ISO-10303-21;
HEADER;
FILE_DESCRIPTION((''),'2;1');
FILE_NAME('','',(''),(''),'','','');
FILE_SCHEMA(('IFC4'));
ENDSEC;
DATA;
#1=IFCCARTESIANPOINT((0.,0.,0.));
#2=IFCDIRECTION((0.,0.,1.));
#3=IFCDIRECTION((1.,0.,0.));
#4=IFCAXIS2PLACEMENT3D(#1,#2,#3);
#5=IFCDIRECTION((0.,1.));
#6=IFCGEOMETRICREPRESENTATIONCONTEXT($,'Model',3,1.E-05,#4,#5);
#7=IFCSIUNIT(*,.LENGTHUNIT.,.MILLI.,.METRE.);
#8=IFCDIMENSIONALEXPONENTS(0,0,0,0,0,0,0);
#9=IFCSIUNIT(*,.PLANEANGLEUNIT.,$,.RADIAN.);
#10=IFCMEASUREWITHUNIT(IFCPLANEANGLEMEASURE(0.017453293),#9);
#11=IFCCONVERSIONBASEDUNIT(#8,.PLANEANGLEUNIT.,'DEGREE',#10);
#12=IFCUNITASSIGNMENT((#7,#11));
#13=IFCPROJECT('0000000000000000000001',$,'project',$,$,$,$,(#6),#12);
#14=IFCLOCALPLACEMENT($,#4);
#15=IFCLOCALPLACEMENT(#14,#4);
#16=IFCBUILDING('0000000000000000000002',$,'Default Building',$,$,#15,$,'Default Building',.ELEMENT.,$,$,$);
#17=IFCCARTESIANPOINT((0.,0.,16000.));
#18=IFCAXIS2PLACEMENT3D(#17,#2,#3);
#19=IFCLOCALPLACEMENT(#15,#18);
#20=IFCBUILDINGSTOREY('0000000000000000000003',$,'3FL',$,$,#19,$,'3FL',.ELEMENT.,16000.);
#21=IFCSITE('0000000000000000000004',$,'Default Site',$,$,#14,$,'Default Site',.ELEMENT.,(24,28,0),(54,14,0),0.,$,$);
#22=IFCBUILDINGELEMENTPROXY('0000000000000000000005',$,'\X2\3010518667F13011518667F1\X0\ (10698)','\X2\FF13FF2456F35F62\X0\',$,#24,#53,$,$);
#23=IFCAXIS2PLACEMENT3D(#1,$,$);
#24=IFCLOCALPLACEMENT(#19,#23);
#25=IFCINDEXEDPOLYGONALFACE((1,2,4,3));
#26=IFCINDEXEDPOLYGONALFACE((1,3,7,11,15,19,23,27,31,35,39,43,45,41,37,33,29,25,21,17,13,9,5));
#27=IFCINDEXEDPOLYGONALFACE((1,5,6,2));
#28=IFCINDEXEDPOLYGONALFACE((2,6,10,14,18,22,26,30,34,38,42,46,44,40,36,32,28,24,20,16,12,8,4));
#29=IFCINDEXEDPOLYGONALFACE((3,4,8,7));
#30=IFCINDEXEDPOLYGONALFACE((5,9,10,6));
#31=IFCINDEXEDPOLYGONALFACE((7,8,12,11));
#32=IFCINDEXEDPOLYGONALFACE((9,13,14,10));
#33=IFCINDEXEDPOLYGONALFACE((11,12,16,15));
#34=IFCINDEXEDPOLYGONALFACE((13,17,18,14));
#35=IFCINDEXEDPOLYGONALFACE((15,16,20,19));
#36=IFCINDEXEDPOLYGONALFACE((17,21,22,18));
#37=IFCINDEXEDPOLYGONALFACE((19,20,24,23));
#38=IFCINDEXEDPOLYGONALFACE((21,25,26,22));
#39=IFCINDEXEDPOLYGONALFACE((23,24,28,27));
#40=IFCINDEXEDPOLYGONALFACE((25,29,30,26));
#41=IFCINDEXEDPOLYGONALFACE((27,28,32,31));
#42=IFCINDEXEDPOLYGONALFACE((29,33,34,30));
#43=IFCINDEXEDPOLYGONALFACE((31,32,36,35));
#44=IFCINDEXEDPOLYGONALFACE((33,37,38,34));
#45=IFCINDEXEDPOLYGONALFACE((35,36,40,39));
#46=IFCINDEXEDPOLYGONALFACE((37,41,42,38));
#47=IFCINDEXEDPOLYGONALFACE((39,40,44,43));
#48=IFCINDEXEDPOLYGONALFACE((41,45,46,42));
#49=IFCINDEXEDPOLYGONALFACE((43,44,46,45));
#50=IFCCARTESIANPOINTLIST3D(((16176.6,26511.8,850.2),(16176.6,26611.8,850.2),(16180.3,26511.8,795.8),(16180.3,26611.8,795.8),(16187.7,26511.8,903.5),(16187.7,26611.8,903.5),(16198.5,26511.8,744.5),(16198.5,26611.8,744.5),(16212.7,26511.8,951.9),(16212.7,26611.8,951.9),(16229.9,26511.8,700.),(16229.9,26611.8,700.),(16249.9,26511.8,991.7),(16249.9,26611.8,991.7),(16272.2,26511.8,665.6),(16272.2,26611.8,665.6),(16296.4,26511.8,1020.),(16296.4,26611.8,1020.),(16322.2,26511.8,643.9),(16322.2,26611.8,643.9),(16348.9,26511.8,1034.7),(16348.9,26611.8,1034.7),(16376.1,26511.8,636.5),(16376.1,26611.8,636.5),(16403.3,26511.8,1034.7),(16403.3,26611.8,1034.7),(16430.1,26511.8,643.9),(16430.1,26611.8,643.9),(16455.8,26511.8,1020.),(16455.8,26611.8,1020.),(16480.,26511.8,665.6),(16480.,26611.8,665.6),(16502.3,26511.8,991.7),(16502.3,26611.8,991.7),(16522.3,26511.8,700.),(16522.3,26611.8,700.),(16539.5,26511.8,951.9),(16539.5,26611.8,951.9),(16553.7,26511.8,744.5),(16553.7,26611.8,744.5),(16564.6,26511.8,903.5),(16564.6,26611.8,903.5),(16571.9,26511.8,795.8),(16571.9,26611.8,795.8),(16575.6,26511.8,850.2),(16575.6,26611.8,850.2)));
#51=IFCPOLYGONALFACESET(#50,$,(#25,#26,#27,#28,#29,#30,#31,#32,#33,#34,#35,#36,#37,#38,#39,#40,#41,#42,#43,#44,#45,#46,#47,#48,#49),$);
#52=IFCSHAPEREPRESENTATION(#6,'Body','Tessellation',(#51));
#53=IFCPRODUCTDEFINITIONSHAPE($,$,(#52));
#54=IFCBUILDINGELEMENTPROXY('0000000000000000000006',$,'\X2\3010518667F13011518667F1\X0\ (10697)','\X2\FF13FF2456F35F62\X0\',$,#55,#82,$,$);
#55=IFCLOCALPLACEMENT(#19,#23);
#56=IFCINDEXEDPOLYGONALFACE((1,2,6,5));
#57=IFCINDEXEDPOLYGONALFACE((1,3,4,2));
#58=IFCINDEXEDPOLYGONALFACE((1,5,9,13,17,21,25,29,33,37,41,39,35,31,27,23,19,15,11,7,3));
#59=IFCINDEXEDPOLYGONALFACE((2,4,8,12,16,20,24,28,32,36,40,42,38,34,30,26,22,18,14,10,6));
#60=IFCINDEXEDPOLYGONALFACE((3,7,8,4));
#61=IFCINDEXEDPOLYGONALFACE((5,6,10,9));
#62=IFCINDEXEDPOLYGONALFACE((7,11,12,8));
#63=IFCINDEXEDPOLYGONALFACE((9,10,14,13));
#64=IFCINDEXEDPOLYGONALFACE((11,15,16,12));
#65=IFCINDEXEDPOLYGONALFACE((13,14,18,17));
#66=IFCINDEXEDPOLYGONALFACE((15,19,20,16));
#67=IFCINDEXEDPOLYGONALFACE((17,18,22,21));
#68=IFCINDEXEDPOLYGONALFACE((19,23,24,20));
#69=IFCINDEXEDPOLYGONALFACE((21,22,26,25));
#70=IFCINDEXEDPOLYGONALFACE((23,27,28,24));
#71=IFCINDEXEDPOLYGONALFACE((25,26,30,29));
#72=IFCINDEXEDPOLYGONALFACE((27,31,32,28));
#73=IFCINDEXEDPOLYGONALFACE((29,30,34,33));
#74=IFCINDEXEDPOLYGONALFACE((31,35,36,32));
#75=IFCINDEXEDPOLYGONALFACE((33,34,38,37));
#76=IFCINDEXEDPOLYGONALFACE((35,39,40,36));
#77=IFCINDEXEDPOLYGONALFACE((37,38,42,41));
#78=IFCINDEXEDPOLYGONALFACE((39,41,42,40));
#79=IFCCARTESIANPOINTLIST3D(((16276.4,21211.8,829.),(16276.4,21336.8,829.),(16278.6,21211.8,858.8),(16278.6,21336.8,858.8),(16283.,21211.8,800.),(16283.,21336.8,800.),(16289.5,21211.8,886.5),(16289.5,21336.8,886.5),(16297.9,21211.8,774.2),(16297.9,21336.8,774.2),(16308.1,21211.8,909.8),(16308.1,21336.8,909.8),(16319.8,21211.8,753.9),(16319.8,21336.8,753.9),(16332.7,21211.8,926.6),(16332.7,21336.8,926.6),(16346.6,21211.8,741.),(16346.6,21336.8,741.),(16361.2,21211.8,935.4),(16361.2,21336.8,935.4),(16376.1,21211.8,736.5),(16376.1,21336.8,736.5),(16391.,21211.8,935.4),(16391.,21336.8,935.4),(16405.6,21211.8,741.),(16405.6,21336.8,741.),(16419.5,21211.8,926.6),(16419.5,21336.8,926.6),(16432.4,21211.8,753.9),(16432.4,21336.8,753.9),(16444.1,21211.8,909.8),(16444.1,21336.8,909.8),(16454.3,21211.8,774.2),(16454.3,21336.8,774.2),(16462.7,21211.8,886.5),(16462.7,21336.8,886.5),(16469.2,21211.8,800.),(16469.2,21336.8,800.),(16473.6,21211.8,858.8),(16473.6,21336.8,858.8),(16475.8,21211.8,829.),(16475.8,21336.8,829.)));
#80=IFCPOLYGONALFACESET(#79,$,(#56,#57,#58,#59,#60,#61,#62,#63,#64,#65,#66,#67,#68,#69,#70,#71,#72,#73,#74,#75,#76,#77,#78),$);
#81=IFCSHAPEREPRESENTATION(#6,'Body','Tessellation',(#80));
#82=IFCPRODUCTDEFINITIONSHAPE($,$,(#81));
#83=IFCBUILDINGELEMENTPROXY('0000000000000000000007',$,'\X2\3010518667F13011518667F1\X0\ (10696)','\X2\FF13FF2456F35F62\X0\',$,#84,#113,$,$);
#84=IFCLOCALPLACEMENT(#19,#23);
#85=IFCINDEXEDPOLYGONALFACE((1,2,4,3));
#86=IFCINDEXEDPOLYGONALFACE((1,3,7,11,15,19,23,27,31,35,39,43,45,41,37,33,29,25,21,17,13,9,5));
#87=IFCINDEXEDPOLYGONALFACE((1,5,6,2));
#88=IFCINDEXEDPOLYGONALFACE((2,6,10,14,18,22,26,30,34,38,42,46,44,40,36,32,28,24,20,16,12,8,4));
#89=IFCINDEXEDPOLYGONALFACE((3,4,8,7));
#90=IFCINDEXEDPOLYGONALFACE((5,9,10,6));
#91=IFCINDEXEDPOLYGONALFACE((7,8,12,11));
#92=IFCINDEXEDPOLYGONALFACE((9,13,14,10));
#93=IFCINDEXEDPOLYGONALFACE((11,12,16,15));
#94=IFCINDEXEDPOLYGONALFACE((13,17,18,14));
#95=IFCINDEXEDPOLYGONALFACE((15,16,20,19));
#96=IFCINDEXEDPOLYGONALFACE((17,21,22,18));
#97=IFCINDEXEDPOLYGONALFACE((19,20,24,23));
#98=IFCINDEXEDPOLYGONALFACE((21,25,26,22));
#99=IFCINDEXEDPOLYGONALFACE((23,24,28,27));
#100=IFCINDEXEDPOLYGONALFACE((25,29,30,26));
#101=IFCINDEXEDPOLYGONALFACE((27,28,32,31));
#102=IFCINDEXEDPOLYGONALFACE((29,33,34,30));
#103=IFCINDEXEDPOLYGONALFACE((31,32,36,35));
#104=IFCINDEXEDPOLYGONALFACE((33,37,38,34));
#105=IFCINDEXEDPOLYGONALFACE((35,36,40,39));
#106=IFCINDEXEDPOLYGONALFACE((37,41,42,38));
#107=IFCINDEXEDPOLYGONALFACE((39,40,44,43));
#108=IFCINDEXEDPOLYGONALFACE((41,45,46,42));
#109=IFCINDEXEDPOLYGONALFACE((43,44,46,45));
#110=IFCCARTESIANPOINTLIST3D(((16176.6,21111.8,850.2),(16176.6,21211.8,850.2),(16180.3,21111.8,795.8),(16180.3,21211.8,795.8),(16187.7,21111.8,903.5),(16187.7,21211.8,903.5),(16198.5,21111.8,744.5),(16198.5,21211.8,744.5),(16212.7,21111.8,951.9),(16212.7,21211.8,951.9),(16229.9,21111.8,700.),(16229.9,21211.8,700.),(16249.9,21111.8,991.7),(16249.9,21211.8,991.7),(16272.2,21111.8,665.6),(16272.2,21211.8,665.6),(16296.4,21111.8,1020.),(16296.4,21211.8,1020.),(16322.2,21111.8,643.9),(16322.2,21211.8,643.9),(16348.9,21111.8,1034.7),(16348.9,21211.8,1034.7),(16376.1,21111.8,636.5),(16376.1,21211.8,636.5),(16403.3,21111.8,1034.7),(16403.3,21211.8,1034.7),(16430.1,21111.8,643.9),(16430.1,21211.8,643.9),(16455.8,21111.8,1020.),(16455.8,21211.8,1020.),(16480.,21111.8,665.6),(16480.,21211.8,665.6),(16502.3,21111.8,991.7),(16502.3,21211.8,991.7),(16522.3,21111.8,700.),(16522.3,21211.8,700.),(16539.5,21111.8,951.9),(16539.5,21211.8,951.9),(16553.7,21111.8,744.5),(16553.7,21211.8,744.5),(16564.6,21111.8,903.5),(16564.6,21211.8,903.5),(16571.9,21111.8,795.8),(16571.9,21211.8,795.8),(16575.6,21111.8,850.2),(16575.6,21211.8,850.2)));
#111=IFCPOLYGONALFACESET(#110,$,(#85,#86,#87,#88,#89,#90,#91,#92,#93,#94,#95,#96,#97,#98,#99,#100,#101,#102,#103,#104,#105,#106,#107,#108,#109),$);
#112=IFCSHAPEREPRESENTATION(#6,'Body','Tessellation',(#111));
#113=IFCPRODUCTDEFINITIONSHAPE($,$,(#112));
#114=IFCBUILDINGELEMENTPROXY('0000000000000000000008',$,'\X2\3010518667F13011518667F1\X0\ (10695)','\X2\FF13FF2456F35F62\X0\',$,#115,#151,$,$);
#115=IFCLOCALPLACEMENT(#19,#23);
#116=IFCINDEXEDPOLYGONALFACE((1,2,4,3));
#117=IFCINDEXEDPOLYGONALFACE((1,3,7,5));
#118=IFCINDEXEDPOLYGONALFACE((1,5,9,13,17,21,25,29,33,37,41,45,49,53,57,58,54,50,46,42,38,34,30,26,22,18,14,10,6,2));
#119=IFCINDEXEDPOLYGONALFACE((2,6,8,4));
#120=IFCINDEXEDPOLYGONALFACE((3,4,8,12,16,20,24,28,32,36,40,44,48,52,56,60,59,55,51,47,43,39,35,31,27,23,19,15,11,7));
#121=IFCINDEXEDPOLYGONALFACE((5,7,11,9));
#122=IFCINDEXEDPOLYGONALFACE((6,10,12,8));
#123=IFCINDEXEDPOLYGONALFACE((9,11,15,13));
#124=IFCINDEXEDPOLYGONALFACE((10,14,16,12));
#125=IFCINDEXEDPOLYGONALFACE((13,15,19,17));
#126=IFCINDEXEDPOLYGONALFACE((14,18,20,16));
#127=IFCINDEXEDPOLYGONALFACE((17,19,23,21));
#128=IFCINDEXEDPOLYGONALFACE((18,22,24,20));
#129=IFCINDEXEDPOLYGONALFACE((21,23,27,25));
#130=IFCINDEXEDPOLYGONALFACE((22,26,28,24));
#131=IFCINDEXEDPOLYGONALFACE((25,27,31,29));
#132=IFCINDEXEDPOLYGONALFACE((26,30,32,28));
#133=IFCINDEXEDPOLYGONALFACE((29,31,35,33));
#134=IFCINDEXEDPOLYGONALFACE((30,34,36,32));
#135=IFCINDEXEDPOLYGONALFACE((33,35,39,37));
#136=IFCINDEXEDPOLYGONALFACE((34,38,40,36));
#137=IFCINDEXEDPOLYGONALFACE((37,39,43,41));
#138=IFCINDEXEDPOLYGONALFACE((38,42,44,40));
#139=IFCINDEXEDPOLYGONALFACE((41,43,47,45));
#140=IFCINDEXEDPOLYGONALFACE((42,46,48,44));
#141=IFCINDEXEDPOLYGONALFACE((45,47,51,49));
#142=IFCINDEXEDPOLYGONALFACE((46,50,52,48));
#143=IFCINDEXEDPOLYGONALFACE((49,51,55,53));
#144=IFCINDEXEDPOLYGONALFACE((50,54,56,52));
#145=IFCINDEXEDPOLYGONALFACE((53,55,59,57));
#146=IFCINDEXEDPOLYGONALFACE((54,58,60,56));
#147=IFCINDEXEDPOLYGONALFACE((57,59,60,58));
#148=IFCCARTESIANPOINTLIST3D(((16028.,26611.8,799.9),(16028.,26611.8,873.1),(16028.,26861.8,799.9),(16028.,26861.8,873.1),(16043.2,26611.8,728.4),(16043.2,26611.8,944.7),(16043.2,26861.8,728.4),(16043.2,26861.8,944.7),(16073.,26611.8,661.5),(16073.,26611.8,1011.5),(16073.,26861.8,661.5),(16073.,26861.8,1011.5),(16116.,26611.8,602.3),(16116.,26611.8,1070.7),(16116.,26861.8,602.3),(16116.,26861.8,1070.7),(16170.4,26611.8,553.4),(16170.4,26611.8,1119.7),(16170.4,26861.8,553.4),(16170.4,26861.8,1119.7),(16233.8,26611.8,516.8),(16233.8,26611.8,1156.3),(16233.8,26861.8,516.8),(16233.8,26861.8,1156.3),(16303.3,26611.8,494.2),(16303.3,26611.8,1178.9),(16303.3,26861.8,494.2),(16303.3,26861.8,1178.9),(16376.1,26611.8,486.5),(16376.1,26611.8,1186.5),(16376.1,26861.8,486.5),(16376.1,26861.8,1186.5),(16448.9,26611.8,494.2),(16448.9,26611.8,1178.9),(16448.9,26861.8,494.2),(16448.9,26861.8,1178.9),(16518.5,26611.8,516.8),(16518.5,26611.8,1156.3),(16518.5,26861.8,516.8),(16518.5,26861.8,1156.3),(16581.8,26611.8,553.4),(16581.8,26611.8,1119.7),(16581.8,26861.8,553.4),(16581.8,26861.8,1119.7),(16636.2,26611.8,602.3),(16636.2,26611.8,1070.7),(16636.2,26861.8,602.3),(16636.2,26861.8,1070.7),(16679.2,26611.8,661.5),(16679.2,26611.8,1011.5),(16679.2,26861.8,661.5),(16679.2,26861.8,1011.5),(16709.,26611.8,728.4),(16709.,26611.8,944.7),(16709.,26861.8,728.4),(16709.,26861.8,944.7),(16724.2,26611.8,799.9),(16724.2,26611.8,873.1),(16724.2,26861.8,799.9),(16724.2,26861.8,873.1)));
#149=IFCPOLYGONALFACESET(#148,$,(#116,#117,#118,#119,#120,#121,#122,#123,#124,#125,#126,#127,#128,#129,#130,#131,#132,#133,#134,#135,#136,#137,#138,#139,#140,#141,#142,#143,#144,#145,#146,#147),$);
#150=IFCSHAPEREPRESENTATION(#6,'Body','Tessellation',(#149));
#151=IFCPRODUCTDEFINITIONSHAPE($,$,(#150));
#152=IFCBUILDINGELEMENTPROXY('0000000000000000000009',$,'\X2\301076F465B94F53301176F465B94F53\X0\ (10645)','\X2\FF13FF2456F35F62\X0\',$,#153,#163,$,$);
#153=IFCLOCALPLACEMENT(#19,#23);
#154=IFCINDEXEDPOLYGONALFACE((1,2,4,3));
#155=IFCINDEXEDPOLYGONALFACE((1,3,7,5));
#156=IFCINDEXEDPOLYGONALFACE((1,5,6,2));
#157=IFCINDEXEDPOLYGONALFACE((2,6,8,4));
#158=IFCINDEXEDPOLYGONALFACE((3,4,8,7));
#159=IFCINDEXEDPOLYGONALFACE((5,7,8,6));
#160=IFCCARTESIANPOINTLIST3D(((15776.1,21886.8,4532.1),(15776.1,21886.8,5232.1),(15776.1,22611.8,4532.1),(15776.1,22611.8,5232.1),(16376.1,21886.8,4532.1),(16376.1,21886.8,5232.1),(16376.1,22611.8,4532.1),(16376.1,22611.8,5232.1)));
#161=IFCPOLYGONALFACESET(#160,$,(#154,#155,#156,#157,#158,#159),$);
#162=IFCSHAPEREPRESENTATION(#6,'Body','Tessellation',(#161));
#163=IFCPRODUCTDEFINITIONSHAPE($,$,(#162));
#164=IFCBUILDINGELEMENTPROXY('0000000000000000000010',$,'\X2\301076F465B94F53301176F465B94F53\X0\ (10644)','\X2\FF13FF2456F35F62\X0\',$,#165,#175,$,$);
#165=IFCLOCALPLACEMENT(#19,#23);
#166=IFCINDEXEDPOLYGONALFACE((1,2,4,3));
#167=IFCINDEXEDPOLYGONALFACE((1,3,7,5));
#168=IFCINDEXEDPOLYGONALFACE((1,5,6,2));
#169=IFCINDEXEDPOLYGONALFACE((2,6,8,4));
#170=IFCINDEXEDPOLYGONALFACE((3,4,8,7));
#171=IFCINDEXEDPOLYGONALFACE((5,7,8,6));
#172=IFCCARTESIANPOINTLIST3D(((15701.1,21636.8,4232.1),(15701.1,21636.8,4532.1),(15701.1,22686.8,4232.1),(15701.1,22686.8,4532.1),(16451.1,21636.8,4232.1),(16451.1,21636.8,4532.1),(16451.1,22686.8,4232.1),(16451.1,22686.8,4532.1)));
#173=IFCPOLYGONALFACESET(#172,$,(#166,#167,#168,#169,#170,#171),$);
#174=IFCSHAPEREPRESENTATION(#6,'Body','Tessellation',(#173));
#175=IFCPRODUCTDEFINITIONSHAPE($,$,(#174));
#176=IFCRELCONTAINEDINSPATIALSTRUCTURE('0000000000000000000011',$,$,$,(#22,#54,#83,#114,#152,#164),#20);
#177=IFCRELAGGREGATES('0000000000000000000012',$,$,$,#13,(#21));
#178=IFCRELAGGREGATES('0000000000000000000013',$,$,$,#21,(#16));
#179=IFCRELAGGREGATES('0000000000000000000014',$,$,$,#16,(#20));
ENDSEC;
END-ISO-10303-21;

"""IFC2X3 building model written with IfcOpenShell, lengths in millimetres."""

from ifc_helpers import new_model, entity, si_unit, converted_unit, direction, frame, origin_with_axes, origin_2d_with_axis, place, context, project, spatial, rectangle, circle, extrude, source, transform, mapped, element, save


model = new_model("IFC2X3")

# Units and contexts
model_context = context("Model", 3, precision=1e-05, world=origin_with_axes(), true_north=direction((0.0, 1.0)))
ifc_project = project(units=[si_unit("LENGTHUNIT", "METRE", prefix="MILLI"), converted_unit("PLANEANGLEUNIT", "DEGREE", entity("IfcPlaneAngleMeasure", 0.017453293), si_unit("PLANEANGLEUNIT", "RADIAN"), dimensions=[0, 0, 0, 0, 0, 0, 0])], contexts=[model_context])

# Site, building, storey
site_placement = place(None, origin_with_axes())
site = spatial("IfcSite", under=ifc_project, at=site_placement, Name="Default Site", LongName="Default Site", CompositionType="ELEMENT", RefLatitude=(24, 28, 0), RefLongitude=(54, 14, 0), RefElevation=0.0)
building_placement = place(site_placement, origin_with_axes())
building = spatial("IfcBuilding", under=site, at=building_placement, Name="Default Building", LongName="Default Building", CompositionType="ELEMENT")
storey_placement = place(building_placement, frame((0.0, 0.0, 16000.0), z_axis=(0.0, 0.0, 1.0), x_axis=(1.0, 0.0, 0.0)))
storey = spatial("IfcBuildingStorey", under=building, at=storey_placement, Name="3FL", LongName="3FL", CompositionType="ELEMENT", Elevation=16000.0)

# Building element proxies
shared_shape_1 = source(origin_with_axes(), model_context, "Body", "SweptSolid", [
    extrude(circle(Radius=200.0, at=origin_2d_with_axis()), frame((0.0, 0.0, 0.0), z_axis=(0.0, 0.0, 1.0), x_axis=(1.0, 0.0, 0.0)), (0.0, 0.0, 1.0), 100.0),
])
proxy_1_placement = place(storey_placement, frame((16376.1, 26511.8, 836.5), z_axis=(0.0, 1.0, 0.0), x_axis=(0.0, 0.0, -1.0)))
element("IfcBuildingElementProxy", 1, at=proxy_1_placement, inside=storey, Name="【円柱】円柱 (10698)", Description="３Ｄ図形", context=model_context, shape_type="MappedRepresentation", body=[
    mapped(shared_shape_1, transform((0.0, 0.0, 0.0))),
])
shared_shape_2 = source(origin_with_axes(), model_context, "Body", "SweptSolid", [
    extrude(circle(Radius=100.0, at=origin_2d_with_axis()), frame((0.0, 0.0, 0.0), z_axis=(0.0, 0.0, 1.0), x_axis=(1.0, 0.0, 0.0)), (0.0, 0.0, 1.0), 125.0),
])
proxy_2_placement = place(storey_placement, frame((16376.1, 21211.8, 836.5), z_axis=(0.0, 1.0, 0.0), x_axis=(0.0, 0.0, -1.0)))
element("IfcBuildingElementProxy", 2, at=proxy_2_placement, inside=storey, Name="【円柱】円柱 (10697)", Description="３Ｄ図形", context=model_context, shape_type="MappedRepresentation", body=[
    mapped(shared_shape_2, transform((0.0, 0.0, 0.0))),
])
shared_shape_3 = source(origin_with_axes(), model_context, "Body", "SweptSolid", [
    extrude(circle(Radius=200.0, at=origin_2d_with_axis()), frame((0.0, 0.0, 0.0), z_axis=(0.0, 0.0, 1.0), x_axis=(1.0, 0.0, 0.0)), (0.0, 0.0, 1.0), 100.0),
])
proxy_3_placement = place(storey_placement, frame((16376.1, 21111.8, 836.5), z_axis=(0.0, 1.0, 0.0), x_axis=(0.0, 0.0, -1.0)))
element("IfcBuildingElementProxy", 3, at=proxy_3_placement, inside=storey, Name="【円柱】円柱 (10696)", Description="３Ｄ図形", context=model_context, shape_type="MappedRepresentation", body=[
    mapped(shared_shape_3, transform((0.0, 0.0, 0.0))),
])
shared_shape_4 = source(origin_with_axes(), model_context, "Body", "SweptSolid", [
    extrude(circle(Radius=350.0, at=origin_2d_with_axis()), frame((0.0, 0.0, 0.0), z_axis=(0.0, 0.0, 1.0), x_axis=(1.0, 0.0, 0.0)), (0.0, 0.0, 1.0), 250.0),
])
proxy_4_placement = place(storey_placement, frame((16376.1, 26611.8, 836.5), z_axis=(0.0, 1.0, 0.0), x_axis=(0.0, 0.0, -1.0)))
element("IfcBuildingElementProxy", 4, at=proxy_4_placement, inside=storey, Name="【円柱】円柱 (10695)", Description="３Ｄ図形", context=model_context, shape_type="MappedRepresentation", body=[
    mapped(shared_shape_4, transform((0.0, 0.0, 0.0))),
])
shared_shape_5 = source(origin_with_axes(), model_context, "Body", "SweptSolid", [
    extrude(rectangle(XDim=600.0, YDim=725.0, at=origin_2d_with_axis()), origin_with_axes(), (0.0, 0.0, 1.0), 700.0),
])
proxy_5_placement = place(storey_placement, frame((16076.1, 22249.3, 4532.1), z_axis=(0.0, 0.0, 1.0), x_axis=(1.0, 0.0, 0.0)))
element("IfcBuildingElementProxy", 5, at=proxy_5_placement, inside=storey, Name="【直方体】直方体 (10645)", Description="３Ｄ図形", context=model_context, shape_type="MappedRepresentation", body=[
    mapped(shared_shape_5, transform((0.0, 0.0, 0.0))),
])
shared_shape_6 = source(origin_with_axes(), model_context, "Body", "SweptSolid", [
    extrude(rectangle(XDim=750.0, YDim=1050.0, at=origin_2d_with_axis()), origin_with_axes(), (0.0, 0.0, 1.0), 300.0),
])
proxy_6_placement = place(storey_placement, frame((16076.1, 22161.8, 4232.1), z_axis=(0.0, 0.0, 1.0), x_axis=(1.0, 0.0, 0.0)))
element("IfcBuildingElementProxy", 6, at=proxy_6_placement, inside=storey, Name="【直方体】直方体 (10644)", Description="３Ｄ図形", context=model_context, shape_type="MappedRepresentation", body=[
    mapped(shared_shape_6, transform((0.0, 0.0, 0.0))),
])

save(model, "model.ifc")
